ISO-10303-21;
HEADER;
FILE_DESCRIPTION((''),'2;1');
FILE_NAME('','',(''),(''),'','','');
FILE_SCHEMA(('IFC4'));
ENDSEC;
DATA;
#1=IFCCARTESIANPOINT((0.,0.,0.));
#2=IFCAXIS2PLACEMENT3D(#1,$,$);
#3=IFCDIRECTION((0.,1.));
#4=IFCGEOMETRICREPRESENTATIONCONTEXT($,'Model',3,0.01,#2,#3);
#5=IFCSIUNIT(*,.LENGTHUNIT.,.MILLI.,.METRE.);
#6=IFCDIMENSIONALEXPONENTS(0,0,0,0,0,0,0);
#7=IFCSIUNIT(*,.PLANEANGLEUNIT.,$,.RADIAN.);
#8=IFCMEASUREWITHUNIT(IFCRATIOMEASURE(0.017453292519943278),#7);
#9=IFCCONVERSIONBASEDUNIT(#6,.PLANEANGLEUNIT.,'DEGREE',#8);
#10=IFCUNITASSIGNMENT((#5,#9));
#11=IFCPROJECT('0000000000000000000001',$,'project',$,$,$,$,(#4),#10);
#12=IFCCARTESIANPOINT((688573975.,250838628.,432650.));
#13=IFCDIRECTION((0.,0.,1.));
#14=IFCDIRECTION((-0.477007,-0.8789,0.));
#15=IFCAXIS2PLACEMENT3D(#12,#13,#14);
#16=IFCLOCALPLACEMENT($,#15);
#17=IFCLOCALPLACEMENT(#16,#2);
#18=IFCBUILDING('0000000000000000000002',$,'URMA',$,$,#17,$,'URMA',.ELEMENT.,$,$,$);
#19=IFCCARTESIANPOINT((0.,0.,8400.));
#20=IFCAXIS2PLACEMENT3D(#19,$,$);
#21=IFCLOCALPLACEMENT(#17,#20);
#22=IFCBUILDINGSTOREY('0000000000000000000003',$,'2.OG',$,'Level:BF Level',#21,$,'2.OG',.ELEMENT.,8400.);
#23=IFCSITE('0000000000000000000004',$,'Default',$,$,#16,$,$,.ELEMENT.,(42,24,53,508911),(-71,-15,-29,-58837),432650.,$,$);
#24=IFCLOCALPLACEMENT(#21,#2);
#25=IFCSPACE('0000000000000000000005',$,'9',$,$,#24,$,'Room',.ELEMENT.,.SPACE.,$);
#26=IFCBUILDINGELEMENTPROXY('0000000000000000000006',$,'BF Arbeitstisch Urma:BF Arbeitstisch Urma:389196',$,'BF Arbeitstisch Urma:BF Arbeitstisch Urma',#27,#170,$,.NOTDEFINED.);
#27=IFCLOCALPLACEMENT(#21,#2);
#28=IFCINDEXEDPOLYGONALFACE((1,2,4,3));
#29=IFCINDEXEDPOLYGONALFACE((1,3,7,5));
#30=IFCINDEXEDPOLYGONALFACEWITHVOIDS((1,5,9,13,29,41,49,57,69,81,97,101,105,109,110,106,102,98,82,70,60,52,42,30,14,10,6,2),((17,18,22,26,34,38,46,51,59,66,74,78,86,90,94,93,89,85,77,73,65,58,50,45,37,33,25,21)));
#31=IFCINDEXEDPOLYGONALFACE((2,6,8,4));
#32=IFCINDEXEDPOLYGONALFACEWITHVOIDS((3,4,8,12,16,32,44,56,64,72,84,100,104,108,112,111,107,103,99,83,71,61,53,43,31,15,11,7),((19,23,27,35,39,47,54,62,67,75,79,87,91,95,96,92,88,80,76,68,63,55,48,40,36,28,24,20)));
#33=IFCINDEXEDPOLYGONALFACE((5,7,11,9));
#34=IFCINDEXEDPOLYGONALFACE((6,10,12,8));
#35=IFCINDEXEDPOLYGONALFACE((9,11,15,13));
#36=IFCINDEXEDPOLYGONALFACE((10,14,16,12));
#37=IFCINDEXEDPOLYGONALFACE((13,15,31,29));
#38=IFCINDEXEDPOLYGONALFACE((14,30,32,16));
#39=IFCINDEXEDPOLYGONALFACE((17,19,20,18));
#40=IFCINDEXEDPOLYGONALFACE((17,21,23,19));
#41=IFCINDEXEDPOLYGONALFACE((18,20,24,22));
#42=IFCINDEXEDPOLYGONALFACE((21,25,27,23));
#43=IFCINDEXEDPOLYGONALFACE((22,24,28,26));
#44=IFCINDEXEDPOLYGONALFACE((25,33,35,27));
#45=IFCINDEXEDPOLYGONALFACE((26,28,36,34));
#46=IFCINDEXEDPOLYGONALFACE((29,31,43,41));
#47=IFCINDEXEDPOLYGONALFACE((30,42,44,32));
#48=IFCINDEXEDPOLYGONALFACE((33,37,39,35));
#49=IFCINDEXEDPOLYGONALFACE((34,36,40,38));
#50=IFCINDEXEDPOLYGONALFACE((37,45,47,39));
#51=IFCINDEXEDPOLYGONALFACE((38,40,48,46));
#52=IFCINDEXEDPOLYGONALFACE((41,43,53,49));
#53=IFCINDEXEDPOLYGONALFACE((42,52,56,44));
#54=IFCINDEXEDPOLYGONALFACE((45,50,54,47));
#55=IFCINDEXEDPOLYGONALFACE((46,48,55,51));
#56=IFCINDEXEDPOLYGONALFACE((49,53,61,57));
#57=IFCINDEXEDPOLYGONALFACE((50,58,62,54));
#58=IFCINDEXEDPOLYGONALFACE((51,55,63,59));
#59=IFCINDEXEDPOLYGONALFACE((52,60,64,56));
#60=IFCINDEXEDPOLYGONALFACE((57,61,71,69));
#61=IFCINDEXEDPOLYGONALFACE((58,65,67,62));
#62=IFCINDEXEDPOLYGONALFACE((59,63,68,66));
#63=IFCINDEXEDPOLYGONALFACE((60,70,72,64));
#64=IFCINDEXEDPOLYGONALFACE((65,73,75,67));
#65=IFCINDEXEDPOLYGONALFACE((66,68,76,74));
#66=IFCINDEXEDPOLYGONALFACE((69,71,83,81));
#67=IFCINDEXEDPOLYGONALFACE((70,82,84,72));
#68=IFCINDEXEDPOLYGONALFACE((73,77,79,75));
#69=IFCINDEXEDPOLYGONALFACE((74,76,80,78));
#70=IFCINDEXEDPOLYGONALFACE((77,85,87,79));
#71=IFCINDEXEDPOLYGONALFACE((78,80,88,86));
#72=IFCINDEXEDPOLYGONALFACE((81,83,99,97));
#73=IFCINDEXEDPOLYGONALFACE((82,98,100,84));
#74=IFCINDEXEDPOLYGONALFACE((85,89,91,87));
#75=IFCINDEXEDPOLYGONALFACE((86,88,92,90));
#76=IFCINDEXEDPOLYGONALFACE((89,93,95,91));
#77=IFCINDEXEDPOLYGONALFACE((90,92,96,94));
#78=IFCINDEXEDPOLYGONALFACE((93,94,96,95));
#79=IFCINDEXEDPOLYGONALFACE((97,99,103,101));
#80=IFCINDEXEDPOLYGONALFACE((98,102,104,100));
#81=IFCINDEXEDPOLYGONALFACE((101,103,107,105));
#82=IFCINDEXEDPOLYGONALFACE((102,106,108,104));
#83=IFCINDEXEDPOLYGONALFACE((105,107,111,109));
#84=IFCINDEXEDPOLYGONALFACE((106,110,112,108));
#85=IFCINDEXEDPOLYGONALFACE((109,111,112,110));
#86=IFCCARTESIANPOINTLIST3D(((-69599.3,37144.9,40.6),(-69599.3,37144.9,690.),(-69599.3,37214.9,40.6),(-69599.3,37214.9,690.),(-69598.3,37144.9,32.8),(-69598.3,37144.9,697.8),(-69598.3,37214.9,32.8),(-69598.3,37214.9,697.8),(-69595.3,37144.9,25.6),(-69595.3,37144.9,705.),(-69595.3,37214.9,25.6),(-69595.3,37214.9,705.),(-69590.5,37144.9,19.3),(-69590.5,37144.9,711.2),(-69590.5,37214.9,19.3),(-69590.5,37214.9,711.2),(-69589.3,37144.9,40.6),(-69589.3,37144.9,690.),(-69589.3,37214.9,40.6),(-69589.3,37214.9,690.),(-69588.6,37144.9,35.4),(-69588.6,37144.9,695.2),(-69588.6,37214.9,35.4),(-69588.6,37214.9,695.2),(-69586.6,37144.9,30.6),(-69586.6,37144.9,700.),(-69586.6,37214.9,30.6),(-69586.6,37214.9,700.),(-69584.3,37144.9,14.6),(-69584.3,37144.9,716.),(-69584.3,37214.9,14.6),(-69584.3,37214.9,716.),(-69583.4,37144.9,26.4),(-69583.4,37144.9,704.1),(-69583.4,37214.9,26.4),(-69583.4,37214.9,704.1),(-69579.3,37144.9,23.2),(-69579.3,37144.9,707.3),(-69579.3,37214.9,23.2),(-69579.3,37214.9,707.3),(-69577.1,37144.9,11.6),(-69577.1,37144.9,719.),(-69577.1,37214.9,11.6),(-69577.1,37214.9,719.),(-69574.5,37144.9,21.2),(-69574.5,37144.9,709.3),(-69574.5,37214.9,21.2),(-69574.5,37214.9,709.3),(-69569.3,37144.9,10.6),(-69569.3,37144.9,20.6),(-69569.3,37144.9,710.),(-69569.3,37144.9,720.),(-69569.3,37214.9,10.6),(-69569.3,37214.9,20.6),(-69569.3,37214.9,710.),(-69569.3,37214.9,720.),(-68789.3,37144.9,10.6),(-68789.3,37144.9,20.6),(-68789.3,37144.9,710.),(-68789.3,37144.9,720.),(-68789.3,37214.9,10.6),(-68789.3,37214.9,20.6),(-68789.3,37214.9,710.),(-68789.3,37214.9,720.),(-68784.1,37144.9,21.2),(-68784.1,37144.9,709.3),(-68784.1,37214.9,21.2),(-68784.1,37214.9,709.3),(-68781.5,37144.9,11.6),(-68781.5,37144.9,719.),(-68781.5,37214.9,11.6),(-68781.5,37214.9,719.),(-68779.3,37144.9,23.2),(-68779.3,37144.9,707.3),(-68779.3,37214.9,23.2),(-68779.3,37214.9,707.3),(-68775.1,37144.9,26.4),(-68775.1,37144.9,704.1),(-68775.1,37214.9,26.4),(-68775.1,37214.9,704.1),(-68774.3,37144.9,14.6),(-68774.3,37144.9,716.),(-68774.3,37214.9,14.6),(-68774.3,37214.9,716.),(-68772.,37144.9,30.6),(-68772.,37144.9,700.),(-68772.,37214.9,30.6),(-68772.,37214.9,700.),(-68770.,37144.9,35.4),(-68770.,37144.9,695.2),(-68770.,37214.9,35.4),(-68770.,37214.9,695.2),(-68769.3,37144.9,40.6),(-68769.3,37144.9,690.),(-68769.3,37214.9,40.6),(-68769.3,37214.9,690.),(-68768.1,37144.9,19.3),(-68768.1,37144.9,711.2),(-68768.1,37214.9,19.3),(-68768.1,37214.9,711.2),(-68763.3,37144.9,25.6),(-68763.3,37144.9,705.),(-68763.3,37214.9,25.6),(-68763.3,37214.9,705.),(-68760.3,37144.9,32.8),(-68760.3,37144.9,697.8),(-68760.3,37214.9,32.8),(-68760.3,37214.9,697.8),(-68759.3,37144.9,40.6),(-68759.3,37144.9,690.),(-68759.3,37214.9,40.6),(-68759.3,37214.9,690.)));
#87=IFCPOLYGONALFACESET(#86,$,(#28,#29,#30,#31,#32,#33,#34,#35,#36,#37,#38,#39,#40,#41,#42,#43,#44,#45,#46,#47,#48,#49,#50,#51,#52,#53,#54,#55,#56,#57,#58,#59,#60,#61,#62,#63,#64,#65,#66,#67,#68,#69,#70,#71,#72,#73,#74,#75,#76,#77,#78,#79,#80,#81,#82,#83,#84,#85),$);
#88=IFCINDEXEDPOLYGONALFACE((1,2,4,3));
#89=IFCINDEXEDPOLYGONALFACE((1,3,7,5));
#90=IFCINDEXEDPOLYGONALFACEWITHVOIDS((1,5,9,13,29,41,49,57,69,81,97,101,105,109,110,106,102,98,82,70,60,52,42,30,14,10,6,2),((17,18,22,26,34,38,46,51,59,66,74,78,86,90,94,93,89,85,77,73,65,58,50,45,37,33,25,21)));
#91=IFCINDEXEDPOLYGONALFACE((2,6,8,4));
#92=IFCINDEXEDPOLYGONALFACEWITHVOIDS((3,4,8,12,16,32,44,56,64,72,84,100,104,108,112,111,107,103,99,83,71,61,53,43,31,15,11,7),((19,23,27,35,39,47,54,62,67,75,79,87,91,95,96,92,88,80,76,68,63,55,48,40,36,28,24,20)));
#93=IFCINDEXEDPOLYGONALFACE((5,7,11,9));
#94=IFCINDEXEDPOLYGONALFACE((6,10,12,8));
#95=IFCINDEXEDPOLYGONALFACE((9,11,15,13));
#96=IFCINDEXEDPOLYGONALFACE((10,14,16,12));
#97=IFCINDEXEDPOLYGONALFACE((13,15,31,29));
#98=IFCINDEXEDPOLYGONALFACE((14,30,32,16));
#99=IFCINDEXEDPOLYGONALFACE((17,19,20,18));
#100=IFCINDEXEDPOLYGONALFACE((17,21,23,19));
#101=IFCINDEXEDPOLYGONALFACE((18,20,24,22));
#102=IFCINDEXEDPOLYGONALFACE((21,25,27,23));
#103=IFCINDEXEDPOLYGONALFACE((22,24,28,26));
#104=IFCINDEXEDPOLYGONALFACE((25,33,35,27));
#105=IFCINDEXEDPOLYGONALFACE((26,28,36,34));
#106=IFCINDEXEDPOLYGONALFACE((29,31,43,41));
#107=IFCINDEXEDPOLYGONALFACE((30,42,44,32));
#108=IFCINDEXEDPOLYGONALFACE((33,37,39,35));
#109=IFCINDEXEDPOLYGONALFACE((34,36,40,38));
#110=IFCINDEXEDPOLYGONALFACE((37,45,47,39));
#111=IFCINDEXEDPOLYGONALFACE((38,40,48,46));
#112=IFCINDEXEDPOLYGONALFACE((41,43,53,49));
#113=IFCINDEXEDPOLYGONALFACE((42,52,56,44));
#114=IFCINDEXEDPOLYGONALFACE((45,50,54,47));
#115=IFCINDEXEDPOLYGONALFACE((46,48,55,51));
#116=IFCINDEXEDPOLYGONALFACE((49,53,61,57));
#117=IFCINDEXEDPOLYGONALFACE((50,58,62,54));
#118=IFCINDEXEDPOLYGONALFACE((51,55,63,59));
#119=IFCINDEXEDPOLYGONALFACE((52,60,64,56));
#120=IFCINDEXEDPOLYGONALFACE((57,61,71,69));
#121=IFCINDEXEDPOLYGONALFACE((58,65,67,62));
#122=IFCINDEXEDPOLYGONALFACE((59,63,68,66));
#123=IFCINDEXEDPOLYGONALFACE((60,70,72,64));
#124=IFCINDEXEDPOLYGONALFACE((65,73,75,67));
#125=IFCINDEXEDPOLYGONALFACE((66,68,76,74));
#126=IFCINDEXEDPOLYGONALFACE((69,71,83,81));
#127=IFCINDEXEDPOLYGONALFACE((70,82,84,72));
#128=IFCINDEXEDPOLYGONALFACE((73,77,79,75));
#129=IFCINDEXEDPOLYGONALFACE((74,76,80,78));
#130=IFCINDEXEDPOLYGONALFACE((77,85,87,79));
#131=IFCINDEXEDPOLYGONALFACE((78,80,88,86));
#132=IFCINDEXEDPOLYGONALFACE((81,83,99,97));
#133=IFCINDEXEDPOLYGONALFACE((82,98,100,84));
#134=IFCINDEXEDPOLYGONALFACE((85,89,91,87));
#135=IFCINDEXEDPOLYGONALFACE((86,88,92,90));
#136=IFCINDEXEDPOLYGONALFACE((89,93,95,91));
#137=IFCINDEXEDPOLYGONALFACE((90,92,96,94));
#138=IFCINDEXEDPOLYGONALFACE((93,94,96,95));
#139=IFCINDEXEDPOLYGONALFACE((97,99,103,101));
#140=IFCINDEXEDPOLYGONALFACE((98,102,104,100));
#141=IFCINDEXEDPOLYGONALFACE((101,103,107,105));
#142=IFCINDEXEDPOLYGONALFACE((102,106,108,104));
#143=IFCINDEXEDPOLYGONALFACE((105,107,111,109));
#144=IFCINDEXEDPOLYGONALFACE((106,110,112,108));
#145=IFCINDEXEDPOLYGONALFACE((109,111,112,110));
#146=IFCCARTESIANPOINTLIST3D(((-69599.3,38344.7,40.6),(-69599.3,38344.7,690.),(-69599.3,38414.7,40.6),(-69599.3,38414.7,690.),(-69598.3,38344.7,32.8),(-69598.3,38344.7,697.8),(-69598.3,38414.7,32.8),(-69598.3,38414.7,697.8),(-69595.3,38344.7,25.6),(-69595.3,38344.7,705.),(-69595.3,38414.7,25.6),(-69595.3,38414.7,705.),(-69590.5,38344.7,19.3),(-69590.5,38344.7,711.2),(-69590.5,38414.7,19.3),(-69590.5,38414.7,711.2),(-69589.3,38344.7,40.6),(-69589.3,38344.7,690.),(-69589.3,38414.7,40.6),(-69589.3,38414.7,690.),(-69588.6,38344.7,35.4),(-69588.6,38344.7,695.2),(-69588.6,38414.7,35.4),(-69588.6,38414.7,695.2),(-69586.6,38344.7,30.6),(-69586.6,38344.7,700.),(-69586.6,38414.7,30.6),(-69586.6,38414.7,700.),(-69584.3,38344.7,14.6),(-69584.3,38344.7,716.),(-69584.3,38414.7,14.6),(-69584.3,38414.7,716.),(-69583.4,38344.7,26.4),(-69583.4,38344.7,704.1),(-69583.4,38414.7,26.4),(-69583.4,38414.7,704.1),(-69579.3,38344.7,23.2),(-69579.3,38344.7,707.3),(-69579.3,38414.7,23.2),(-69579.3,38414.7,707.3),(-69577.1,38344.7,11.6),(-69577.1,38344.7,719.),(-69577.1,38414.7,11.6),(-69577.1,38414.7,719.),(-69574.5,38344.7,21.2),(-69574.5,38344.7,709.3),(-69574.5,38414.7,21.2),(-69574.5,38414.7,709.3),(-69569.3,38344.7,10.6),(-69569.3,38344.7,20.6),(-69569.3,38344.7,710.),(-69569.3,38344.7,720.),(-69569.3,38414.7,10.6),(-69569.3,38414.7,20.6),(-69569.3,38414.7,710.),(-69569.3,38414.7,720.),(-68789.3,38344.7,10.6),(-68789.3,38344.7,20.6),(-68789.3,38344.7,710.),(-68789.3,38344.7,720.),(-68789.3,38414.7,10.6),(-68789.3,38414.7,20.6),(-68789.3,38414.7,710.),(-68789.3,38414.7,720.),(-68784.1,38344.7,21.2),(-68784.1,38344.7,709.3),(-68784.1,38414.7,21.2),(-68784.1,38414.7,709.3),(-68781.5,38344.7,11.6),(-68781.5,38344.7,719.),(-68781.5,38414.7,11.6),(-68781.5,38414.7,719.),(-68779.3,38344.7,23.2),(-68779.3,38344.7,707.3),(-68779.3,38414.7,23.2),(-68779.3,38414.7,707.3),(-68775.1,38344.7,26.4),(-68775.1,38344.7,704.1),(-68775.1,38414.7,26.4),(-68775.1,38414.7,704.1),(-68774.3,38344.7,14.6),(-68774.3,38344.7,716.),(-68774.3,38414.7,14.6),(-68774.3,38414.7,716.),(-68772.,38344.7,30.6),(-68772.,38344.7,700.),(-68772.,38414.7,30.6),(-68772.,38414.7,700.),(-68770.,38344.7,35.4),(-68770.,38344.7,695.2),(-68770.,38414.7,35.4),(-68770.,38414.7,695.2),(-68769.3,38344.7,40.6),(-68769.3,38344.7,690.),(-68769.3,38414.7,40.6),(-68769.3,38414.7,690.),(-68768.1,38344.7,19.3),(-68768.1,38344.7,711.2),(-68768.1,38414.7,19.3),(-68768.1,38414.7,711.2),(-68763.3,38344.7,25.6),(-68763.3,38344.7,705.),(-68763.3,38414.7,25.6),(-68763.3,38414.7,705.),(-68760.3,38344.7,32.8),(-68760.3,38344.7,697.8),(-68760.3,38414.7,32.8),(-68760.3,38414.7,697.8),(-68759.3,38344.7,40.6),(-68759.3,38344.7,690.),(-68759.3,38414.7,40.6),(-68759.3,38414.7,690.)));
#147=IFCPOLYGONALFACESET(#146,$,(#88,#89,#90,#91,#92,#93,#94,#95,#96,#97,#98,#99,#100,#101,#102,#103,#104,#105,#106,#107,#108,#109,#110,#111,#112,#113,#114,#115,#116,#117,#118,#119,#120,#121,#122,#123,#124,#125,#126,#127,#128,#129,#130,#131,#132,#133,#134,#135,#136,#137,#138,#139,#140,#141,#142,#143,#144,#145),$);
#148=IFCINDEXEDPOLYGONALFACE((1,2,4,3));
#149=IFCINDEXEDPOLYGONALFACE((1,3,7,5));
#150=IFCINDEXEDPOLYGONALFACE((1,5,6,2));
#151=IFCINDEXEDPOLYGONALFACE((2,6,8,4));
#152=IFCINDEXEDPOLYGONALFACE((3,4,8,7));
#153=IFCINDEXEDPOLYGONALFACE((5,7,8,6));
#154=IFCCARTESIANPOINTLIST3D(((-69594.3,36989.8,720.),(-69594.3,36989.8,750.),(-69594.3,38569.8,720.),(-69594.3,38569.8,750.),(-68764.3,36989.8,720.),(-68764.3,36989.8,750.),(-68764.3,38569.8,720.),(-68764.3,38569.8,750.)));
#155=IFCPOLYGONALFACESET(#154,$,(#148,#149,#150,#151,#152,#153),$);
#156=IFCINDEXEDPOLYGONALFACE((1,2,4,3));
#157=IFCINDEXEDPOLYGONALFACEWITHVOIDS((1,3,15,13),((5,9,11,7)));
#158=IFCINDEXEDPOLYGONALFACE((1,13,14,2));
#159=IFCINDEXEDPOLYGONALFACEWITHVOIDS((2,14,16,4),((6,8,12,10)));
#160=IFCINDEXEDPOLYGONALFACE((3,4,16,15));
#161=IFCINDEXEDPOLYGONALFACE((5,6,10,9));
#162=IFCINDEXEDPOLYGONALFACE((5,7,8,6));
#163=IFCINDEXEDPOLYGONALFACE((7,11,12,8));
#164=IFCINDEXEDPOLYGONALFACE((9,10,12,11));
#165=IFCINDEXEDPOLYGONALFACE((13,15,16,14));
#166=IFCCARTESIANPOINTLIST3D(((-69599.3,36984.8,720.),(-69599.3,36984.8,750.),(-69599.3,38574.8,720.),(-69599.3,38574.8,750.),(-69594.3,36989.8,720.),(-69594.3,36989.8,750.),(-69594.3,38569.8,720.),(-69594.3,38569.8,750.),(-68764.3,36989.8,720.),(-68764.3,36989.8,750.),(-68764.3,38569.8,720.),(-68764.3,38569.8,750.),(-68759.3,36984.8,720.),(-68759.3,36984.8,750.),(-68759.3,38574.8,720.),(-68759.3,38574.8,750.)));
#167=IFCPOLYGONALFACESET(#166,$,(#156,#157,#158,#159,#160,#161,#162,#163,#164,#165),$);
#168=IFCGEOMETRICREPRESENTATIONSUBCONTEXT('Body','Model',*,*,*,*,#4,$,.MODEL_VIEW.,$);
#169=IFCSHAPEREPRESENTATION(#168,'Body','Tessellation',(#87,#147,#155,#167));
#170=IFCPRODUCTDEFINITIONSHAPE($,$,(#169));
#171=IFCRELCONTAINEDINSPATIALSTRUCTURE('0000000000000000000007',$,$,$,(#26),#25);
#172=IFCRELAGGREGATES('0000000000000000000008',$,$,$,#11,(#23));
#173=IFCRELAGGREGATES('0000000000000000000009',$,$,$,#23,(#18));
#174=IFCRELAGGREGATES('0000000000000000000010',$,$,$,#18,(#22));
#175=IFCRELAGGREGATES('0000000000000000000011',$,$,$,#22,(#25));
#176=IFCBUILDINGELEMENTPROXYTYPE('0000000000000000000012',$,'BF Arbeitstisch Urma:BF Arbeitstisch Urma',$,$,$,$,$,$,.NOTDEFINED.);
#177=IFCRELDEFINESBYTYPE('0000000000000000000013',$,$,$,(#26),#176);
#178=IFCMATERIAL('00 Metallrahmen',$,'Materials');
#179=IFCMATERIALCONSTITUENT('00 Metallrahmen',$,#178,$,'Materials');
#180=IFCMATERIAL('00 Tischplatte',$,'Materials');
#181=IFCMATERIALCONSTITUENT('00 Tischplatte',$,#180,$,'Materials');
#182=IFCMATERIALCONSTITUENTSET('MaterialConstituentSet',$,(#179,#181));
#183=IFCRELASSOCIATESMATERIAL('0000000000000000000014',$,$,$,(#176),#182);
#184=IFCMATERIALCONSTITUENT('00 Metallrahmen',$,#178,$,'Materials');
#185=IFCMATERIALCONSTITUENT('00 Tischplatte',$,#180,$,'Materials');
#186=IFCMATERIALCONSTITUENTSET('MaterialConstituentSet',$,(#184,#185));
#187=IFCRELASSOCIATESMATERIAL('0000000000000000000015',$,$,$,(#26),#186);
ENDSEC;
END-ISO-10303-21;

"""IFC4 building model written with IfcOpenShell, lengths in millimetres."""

from ifc_helpers import new_model, entity, si_unit, converted_unit, direction, frame, origin, place, context, subcontext, project, spatial, line, arc, indexed_curve, outline, extrude, source, transform, mapped, material, constituent, constituent_set, type_object, type_shapes, element, save


model = new_model("IFC4")

# Units and contexts
model_context = context("Model", 3, precision=0.01, world=origin(), true_north=direction((0.0, 1.0)))
body_context = subcontext(model_context, "Body", "Model", "MODEL_VIEW")
ifc_project = project(units=[si_unit("LENGTHUNIT", "METRE", prefix="MILLI"), converted_unit("PLANEANGLEUNIT", "DEGREE", entity("IfcRatioMeasure", 0.017453292519943278), si_unit("PLANEANGLEUNIT", "RADIAN"), dimensions=[0, 0, 0, 0, 0, 0, 0])], contexts=[model_context])

# Site, building, storey
site_placement = place(None, frame((688573975.0, 250838628.0, 432650.0), z_axis=(0.0, 0.0, 1.0), x_axis=(-0.477007, -0.8789, 0.0)))
site = spatial("IfcSite", under=ifc_project, at=site_placement, Name="Default", CompositionType="ELEMENT", RefLatitude=(42, 24, 53, 508911), RefLongitude=(-71, -15, -29, -58837), RefElevation=432650.0)
building_placement = place(site_placement, origin())
building = spatial("IfcBuilding", under=site, at=building_placement, Name="URMA", LongName="URMA", CompositionType="ELEMENT")
storey_placement = place(building_placement, frame((0.0, 0.0, 8400.0)))
storey = spatial("IfcBuildingStorey", under=building, at=storey_placement, Name="2.OG", ObjectType="Level:BF Level", LongName="2.OG", CompositionType="ELEMENT", Elevation=8400.0)

# Shared definitions
ifc_material_1 = material(Name="00 Metallrahmen", Category="Materials")

# Shared definitions
space_1_placement = place(storey_placement, origin())
space_1 = spatial("IfcSpace", under=storey, at=space_1_placement, Name="9", LongName="Room", CompositionType="ELEMENT", PredefinedType="SPACE")

# Building element proxy
ifc_constituent_1 = constituent(ifc_material_1, Name="00 Metallrahmen", Category="Materials")
ifc_material_2 = material(Name="00 Tischplatte", Category="Materials")
ifc_constituent_2 = constituent(ifc_material_2, Name="00 Tischplatte", Category="Materials")
ifc_constituent_set_1 = constituent_set(constituents=[ifc_constituent_1, ifc_constituent_2], Name="MaterialConstituentSet")
ifc_constituent_3 = constituent(ifc_material_1, Name="00 Metallrahmen", Category="Materials")
ifc_constituent_4 = constituent(ifc_material_2, Name="00 Tischplatte", Category="Materials")
ifc_constituent_set_2 = constituent_set(constituents=[ifc_constituent_3, ifc_constituent_4], Name="MaterialConstituentSet")
building_element_proxy_type_1 = type_object("IfcBuildingElementProxyType", Name="BF Arbeitstisch Urma:BF Arbeitstisch Urma", PredefinedType="NOTDEFINED", material=ifc_constituent_set_2)
shared_shape_1 = source(origin(), body_context, "Body", "SweptSolid", [
    extrude(outline(indexed_curve([(-390.0, -354.7), (390.0, -354.7), (411.2, -345.9), (420.0, -324.7), (420.0, 324.7), (411.2, 345.9), (390.0, 354.7), (-390.0, 354.7), (-411.2, 345.9), (-420.0, 324.7), (-420.0, -324.7), (-411.2, -345.9)], segments=[line(1, 2), arc(2, 3, 4), line(4, 5), arc(5, 6, 7), line(7, 8), arc(8, 9, 10), line(10, 11), arc(11, 12, 1)], self_intersect=False), holes=[indexed_curve([(410.0, 324.7), (410.0, -324.7), (404.1, -338.9), (390.0, -344.7), (-390.0, -344.7), (-404.1, -338.9), (-410.0, -324.7), (-410.0, 324.7), (-404.1, 338.9), (-390.0, 344.7), (390.0, 344.7), (404.1, 338.9)], segments=[line(1, 2), arc(2, 3, 4), line(4, 5), arc(5, 6, 7), line(7, 8), arc(8, 9, 10), line(10, 11), arc(11, 12, 1)], self_intersect=False)]), frame((-634.4, -4.8, 365.3), z_axis=(1.0, 0.0, 0.0), x_axis=(0.0, -1.0, 0.0)), (0.0, 0.0, 1.0), 70.0),
    extrude(outline(indexed_curve([(-390.0, -354.7), (390.0, -354.7), (411.2, -345.9), (420.0, -324.7), (420.0, 324.7), (411.2, 345.9), (390.0, 354.7), (-390.0, 354.7), (-411.2, 345.9), (-420.0, 324.7), (-420.0, -324.7), (-411.2, -345.9)], segments=[line(1, 2), arc(2, 3, 4), line(4, 5), arc(5, 6, 7), line(7, 8), arc(8, 9, 10), line(10, 11), arc(11, 12, 1)], self_intersect=False), holes=[indexed_curve([(410.0, 324.7), (410.0, -324.7), (404.1, -338.9), (390.0, -344.7), (-390.0, -344.7), (-404.1, -338.9), (-410.0, -324.7), (-410.0, 324.7), (-404.1, 338.9), (-390.0, 344.7), (390.0, 344.7), (404.1, 338.9)], segments=[line(1, 2), arc(2, 3, 4), line(4, 5), arc(5, 6, 7), line(7, 8), arc(8, 9, 10), line(10, 11), arc(11, 12, 1)], self_intersect=False)]), frame((565.4, -4.8, 365.3), z_axis=(1.0, 0.0, 0.0), x_axis=(0.0, -1.0, 0.0)), (0.0, 0.0, 1.0), 70.0),
    extrude(outline(indexed_curve([(-790.0, -415.0), (790.0, -415.0), (790.0, 415.0), (-790.0, 415.0), (-790.0, -415.0)], self_intersect=False)), frame((0.5, -4.8, 720.0), z_axis=(0.0, 0.0, 1.0), x_axis=(-1.0, 0.0, 0.0)), (0.0, 0.0, 1.0), 30.0),
    extrude(outline(indexed_curve([(-795.0, -420.0), (795.0, -420.0), (795.0, 420.0), (-795.0, 420.0), (-795.0, -420.0)], self_intersect=False), holes=[indexed_curve([(790.0, 415.0), (790.0, -415.0), (-790.0, -415.0), (-790.0, 415.0), (790.0, 415.0)], self_intersect=False)]), frame((0.5, -4.8, 720.0)), (0.0, 0.0, 1.0), 30.0),
])
type_shapes(building_element_proxy_type_1, [shared_shape_1])
proxy_1_placement = place(space_1_placement, frame((-69184.1, 37779.3, 0.0), z_axis=(0.0, 0.0, 1.0), x_axis=(0.0, 1.0, 0.0)))
element("IfcBuildingElementProxy", 1, at=proxy_1_placement, inside=space_1, type_object=building_element_proxy_type_1, material=ifc_constituent_set_1, Name="BF Arbeitstisch Urma:BF Arbeitstisch Urma:389196", ObjectType="BF Arbeitstisch Urma:BF Arbeitstisch Urma", PredefinedType="NOTDEFINED", context=body_context, shape_type="MappedRepresentation", body=[
    mapped(shared_shape_1, transform((0.0, 0.0, 0.0), scale=1.0)),
])

save(model, "model.ifc")
